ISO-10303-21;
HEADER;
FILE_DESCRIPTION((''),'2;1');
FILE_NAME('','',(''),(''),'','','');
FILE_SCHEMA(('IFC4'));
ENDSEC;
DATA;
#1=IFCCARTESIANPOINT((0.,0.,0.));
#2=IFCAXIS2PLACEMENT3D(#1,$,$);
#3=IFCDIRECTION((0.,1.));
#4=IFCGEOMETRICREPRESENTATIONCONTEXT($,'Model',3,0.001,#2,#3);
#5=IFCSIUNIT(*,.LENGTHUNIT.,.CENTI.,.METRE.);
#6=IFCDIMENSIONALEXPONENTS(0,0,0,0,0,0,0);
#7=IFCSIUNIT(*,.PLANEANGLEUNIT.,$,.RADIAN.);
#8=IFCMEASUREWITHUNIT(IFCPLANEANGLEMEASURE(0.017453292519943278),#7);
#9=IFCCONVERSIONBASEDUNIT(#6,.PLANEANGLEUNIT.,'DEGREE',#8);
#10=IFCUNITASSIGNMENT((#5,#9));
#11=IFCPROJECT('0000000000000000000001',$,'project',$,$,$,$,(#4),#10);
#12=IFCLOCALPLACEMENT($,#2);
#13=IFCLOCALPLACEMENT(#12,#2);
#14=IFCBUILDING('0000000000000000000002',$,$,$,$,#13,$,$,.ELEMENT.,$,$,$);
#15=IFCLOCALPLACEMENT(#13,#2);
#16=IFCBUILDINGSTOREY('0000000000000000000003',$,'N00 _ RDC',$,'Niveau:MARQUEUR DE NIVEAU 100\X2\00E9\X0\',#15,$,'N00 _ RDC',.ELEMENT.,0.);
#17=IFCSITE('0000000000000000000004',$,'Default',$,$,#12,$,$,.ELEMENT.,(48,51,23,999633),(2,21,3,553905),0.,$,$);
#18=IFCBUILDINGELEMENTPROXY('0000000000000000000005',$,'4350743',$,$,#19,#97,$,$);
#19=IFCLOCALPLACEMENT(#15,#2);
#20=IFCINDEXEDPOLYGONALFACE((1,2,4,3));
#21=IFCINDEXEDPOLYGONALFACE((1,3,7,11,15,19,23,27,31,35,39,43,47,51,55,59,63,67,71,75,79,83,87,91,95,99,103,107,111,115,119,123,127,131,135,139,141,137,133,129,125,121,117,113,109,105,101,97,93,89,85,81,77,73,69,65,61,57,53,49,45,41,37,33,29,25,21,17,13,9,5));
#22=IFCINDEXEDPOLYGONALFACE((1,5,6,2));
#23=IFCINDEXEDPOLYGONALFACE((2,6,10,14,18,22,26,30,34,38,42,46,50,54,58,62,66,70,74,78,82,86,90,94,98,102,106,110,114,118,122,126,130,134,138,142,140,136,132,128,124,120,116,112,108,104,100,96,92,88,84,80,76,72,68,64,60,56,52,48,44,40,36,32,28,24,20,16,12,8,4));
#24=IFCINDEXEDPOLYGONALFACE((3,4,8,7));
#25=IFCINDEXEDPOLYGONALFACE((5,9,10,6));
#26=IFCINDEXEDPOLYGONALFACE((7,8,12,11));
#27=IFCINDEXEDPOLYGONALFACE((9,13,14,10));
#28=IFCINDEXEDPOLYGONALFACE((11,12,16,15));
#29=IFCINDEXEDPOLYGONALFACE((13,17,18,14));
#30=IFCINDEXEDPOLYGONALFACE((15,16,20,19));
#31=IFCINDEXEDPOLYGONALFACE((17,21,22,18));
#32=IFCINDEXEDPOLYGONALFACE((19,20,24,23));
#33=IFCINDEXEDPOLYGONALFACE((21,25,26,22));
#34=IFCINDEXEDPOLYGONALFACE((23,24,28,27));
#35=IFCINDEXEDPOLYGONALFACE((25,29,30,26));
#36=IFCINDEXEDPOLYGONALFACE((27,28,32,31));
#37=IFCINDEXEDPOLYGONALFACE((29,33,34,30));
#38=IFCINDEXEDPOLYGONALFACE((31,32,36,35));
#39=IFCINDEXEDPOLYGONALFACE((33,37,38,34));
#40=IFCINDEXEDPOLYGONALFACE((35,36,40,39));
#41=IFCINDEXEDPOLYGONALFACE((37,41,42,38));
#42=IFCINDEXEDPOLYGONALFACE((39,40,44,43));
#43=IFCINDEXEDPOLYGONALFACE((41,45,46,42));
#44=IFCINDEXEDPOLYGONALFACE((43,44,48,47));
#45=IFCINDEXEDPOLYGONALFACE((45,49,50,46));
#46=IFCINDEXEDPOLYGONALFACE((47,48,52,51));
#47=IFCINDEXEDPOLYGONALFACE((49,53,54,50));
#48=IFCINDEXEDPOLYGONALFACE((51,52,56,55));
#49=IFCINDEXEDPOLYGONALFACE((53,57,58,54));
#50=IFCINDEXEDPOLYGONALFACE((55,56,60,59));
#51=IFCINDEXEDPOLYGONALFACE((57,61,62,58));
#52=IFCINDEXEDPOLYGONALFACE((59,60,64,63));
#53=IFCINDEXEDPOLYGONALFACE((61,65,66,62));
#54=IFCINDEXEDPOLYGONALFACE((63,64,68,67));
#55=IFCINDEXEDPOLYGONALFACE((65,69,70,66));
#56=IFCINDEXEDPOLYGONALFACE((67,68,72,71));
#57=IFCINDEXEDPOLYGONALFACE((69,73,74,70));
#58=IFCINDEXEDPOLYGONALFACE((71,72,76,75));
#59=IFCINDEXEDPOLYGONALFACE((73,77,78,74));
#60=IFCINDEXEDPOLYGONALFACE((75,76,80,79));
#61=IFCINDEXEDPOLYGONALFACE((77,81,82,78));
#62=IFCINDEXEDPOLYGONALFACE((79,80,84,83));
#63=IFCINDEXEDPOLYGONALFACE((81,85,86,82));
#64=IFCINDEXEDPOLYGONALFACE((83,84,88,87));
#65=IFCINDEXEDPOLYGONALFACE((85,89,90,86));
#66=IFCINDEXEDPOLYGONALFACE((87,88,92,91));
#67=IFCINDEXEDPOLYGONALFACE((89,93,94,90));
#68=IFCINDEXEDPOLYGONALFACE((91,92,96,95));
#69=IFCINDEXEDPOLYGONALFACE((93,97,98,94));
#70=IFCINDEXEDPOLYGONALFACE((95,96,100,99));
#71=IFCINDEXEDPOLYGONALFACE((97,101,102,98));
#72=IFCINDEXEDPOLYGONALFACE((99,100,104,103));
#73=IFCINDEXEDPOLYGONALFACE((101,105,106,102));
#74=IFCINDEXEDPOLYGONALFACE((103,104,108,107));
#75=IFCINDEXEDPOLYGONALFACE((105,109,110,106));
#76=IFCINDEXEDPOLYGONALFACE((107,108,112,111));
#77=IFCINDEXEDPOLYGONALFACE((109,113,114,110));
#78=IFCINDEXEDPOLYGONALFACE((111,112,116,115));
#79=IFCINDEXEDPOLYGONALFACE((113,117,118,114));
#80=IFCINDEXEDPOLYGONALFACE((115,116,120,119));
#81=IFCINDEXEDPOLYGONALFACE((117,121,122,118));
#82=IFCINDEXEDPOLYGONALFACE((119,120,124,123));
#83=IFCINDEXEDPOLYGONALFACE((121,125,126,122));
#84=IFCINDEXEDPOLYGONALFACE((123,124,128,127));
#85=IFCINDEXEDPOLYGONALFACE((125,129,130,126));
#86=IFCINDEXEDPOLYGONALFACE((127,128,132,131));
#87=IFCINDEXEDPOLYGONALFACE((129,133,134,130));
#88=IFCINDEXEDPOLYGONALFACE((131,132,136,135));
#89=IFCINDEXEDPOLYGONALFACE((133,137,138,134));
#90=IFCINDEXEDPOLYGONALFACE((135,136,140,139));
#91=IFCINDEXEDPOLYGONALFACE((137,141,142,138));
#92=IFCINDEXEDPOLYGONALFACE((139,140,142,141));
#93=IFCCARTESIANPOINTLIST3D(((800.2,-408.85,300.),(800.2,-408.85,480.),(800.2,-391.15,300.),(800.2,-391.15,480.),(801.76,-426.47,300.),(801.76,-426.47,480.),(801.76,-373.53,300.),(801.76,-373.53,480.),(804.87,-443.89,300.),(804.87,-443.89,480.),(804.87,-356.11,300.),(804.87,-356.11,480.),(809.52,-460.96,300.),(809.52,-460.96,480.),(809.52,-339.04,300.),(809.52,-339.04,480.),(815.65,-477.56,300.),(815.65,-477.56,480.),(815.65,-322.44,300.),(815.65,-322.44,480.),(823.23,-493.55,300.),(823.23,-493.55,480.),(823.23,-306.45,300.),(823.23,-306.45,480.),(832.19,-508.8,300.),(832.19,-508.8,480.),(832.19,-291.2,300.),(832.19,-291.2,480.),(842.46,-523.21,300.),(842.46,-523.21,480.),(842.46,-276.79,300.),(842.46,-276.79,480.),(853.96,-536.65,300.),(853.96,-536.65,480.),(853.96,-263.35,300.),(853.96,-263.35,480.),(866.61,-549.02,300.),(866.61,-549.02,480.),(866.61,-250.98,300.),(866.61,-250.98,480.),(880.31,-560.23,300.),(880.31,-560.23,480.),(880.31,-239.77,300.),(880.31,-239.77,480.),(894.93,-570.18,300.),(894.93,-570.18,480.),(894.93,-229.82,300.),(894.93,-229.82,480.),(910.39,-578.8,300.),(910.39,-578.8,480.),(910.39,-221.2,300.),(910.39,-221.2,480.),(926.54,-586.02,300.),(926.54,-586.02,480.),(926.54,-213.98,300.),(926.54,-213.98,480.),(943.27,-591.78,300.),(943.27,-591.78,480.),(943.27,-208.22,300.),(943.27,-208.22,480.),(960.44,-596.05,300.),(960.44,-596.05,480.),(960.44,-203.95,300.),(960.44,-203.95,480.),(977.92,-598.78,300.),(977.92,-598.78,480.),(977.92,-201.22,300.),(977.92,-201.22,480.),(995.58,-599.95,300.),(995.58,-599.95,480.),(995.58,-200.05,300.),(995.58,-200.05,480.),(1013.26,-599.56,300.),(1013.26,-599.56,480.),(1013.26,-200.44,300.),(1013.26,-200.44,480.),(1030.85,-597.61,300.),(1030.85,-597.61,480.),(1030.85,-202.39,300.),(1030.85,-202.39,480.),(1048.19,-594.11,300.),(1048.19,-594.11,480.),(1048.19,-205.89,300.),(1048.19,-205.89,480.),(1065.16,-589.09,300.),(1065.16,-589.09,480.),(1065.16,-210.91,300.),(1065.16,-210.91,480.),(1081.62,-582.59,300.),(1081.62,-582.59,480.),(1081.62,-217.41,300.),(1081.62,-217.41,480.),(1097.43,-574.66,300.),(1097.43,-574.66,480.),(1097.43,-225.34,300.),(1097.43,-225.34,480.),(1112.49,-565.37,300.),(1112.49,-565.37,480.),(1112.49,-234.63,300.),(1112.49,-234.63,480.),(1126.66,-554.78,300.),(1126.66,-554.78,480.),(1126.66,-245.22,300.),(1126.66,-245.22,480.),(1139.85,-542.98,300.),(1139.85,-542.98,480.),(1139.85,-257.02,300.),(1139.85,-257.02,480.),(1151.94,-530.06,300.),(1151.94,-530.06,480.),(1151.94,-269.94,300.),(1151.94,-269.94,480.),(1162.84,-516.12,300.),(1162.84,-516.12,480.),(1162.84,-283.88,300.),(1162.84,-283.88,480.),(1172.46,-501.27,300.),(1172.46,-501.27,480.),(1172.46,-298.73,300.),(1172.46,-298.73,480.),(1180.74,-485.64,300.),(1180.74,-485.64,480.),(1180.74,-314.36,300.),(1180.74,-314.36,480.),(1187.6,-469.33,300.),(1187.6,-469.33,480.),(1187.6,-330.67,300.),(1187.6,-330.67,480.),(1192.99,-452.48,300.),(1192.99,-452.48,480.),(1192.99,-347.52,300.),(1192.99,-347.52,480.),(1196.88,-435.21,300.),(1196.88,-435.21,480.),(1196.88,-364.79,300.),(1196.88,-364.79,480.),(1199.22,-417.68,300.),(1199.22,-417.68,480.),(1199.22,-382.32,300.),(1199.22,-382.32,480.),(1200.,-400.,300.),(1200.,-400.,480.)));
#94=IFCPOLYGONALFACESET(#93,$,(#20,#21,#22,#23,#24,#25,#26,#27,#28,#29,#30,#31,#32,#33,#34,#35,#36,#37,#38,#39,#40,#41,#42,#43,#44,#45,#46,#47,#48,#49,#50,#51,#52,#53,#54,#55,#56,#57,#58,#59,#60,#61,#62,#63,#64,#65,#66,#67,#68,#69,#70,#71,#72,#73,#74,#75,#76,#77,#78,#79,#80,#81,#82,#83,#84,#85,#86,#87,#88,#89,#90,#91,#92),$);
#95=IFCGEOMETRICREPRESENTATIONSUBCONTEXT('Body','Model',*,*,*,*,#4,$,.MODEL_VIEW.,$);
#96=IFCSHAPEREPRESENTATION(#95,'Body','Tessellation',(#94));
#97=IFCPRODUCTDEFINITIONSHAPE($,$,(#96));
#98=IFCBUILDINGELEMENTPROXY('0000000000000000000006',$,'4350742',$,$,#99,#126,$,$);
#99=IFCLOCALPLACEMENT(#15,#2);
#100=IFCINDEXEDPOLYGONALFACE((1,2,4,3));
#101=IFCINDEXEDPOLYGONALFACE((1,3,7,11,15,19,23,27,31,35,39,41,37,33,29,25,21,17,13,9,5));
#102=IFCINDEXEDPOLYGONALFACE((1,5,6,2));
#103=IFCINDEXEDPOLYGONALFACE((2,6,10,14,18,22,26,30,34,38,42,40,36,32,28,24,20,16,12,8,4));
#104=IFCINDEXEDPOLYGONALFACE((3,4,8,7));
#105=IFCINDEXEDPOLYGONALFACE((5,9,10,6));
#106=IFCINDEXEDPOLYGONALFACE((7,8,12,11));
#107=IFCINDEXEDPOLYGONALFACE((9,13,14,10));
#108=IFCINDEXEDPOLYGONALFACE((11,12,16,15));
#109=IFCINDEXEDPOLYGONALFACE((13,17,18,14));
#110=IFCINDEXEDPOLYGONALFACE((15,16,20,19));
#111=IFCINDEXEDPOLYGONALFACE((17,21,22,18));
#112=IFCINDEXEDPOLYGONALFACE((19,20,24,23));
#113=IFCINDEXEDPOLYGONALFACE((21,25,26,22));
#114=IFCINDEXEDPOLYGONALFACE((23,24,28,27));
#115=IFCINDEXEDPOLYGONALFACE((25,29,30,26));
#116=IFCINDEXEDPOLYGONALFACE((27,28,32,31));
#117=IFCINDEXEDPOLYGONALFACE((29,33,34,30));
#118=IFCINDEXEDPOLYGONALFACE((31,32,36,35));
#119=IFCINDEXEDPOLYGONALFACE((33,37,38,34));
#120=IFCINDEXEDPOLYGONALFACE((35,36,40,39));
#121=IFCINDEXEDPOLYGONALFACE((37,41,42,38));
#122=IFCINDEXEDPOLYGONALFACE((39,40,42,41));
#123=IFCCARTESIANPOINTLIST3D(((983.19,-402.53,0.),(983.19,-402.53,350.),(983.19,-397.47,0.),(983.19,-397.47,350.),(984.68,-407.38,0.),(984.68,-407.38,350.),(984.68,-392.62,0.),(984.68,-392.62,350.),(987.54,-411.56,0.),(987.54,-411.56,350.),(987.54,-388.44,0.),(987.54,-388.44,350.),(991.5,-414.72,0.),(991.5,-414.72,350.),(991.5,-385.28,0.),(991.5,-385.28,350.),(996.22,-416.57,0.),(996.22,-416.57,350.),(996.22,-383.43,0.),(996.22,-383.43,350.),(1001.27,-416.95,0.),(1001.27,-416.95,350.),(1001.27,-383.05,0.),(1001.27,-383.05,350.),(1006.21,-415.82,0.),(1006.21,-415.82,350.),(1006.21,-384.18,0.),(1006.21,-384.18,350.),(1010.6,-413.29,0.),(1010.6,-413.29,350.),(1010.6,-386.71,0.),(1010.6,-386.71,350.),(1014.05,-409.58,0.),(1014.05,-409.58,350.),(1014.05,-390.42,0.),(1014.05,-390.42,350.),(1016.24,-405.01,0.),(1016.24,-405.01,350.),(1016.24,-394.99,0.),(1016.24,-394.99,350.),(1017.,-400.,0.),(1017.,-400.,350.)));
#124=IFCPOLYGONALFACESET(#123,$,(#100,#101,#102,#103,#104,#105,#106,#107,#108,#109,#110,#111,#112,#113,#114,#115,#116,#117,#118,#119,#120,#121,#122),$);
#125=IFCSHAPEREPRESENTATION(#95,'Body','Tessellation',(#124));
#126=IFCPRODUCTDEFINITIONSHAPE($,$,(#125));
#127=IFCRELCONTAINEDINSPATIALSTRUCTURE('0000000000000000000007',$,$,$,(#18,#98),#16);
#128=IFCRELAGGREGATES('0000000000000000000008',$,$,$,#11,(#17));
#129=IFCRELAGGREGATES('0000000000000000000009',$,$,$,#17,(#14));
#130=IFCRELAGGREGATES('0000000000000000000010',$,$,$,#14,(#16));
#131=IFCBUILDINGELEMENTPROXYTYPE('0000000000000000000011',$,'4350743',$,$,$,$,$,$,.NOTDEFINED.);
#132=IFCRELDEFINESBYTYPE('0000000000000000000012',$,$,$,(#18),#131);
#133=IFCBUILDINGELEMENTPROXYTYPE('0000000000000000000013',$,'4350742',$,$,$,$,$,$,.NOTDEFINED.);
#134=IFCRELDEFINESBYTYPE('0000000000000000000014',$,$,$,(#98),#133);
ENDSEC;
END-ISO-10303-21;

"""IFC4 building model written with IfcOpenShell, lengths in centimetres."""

from ifc_helpers import new_model, entity, si_unit, converted_unit, direction, frame, origin, origin_2d_with_axis, place, context, subcontext, project, spatial, circle, extrude, type_object, element, save


model = new_model("IFC4")

# Units and contexts
model_context = context("Model", 3, precision=0.001, world=origin(), true_north=direction((0.0, 1.0)))
body_context = subcontext(model_context, "Body", "Model", "MODEL_VIEW")
ifc_project = project(units=[si_unit("LENGTHUNIT", "METRE", prefix="CENTI"), converted_unit("PLANEANGLEUNIT", "DEGREE", entity("IfcPlaneAngleMeasure", 0.017453292519943278), si_unit("PLANEANGLEUNIT", "RADIAN"), dimensions=[0, 0, 0, 0, 0, 0, 0])], contexts=[model_context])

# Site, building, storey
site_placement = place(None, origin())
site = spatial("IfcSite", under=ifc_project, at=site_placement, Name="Default", CompositionType="ELEMENT", RefLatitude=(48, 51, 23, 999633), RefLongitude=(2, 21, 3, 553905), RefElevation=0.0)
building_placement = place(site_placement, origin())
building = spatial("IfcBuilding", under=site, at=building_placement, CompositionType="ELEMENT")
storey_placement = place(building_placement, origin())
storey = spatial("IfcBuildingStorey", under=building, at=storey_placement, Name="N00 _ RDC", ObjectType="Niveau:MARQUEUR DE NIVEAU 100é", LongName="N00 _ RDC", CompositionType="ELEMENT", Elevation=0.0)

# Building element proxies
building_element_proxy_type_1 = type_object("IfcBuildingElementProxyType", Name="4350743", PredefinedType="NOTDEFINED")
proxy_1_placement = place(storey_placement, origin())
element("IfcBuildingElementProxy", 1, at=proxy_1_placement, inside=storey, type_object=building_element_proxy_type_1, Name="4350743", context=body_context, shape_type="SweptSolid", body=[
    extrude(circle(Radius=200.0, at=origin_2d_with_axis()), frame((1000.0, -400.0, 300.0)), (0.0, 0.0, 1.0), 180.0),
])
building_element_proxy_type_2 = type_object("IfcBuildingElementProxyType", Name="4350742", PredefinedType="NOTDEFINED")
proxy_2_placement = place(storey_placement, origin())
element("IfcBuildingElementProxy", 2, at=proxy_2_placement, inside=storey, type_object=building_element_proxy_type_2, Name="4350742", context=body_context, shape_type="SweptSolid", body=[
    extrude(circle(Radius=17.0, at=origin_2d_with_axis()), frame((1000.0, -400.0, 0.0)), (0.0, 0.0, 1.0), 350.0),
])

save(model, "model.ifc")
